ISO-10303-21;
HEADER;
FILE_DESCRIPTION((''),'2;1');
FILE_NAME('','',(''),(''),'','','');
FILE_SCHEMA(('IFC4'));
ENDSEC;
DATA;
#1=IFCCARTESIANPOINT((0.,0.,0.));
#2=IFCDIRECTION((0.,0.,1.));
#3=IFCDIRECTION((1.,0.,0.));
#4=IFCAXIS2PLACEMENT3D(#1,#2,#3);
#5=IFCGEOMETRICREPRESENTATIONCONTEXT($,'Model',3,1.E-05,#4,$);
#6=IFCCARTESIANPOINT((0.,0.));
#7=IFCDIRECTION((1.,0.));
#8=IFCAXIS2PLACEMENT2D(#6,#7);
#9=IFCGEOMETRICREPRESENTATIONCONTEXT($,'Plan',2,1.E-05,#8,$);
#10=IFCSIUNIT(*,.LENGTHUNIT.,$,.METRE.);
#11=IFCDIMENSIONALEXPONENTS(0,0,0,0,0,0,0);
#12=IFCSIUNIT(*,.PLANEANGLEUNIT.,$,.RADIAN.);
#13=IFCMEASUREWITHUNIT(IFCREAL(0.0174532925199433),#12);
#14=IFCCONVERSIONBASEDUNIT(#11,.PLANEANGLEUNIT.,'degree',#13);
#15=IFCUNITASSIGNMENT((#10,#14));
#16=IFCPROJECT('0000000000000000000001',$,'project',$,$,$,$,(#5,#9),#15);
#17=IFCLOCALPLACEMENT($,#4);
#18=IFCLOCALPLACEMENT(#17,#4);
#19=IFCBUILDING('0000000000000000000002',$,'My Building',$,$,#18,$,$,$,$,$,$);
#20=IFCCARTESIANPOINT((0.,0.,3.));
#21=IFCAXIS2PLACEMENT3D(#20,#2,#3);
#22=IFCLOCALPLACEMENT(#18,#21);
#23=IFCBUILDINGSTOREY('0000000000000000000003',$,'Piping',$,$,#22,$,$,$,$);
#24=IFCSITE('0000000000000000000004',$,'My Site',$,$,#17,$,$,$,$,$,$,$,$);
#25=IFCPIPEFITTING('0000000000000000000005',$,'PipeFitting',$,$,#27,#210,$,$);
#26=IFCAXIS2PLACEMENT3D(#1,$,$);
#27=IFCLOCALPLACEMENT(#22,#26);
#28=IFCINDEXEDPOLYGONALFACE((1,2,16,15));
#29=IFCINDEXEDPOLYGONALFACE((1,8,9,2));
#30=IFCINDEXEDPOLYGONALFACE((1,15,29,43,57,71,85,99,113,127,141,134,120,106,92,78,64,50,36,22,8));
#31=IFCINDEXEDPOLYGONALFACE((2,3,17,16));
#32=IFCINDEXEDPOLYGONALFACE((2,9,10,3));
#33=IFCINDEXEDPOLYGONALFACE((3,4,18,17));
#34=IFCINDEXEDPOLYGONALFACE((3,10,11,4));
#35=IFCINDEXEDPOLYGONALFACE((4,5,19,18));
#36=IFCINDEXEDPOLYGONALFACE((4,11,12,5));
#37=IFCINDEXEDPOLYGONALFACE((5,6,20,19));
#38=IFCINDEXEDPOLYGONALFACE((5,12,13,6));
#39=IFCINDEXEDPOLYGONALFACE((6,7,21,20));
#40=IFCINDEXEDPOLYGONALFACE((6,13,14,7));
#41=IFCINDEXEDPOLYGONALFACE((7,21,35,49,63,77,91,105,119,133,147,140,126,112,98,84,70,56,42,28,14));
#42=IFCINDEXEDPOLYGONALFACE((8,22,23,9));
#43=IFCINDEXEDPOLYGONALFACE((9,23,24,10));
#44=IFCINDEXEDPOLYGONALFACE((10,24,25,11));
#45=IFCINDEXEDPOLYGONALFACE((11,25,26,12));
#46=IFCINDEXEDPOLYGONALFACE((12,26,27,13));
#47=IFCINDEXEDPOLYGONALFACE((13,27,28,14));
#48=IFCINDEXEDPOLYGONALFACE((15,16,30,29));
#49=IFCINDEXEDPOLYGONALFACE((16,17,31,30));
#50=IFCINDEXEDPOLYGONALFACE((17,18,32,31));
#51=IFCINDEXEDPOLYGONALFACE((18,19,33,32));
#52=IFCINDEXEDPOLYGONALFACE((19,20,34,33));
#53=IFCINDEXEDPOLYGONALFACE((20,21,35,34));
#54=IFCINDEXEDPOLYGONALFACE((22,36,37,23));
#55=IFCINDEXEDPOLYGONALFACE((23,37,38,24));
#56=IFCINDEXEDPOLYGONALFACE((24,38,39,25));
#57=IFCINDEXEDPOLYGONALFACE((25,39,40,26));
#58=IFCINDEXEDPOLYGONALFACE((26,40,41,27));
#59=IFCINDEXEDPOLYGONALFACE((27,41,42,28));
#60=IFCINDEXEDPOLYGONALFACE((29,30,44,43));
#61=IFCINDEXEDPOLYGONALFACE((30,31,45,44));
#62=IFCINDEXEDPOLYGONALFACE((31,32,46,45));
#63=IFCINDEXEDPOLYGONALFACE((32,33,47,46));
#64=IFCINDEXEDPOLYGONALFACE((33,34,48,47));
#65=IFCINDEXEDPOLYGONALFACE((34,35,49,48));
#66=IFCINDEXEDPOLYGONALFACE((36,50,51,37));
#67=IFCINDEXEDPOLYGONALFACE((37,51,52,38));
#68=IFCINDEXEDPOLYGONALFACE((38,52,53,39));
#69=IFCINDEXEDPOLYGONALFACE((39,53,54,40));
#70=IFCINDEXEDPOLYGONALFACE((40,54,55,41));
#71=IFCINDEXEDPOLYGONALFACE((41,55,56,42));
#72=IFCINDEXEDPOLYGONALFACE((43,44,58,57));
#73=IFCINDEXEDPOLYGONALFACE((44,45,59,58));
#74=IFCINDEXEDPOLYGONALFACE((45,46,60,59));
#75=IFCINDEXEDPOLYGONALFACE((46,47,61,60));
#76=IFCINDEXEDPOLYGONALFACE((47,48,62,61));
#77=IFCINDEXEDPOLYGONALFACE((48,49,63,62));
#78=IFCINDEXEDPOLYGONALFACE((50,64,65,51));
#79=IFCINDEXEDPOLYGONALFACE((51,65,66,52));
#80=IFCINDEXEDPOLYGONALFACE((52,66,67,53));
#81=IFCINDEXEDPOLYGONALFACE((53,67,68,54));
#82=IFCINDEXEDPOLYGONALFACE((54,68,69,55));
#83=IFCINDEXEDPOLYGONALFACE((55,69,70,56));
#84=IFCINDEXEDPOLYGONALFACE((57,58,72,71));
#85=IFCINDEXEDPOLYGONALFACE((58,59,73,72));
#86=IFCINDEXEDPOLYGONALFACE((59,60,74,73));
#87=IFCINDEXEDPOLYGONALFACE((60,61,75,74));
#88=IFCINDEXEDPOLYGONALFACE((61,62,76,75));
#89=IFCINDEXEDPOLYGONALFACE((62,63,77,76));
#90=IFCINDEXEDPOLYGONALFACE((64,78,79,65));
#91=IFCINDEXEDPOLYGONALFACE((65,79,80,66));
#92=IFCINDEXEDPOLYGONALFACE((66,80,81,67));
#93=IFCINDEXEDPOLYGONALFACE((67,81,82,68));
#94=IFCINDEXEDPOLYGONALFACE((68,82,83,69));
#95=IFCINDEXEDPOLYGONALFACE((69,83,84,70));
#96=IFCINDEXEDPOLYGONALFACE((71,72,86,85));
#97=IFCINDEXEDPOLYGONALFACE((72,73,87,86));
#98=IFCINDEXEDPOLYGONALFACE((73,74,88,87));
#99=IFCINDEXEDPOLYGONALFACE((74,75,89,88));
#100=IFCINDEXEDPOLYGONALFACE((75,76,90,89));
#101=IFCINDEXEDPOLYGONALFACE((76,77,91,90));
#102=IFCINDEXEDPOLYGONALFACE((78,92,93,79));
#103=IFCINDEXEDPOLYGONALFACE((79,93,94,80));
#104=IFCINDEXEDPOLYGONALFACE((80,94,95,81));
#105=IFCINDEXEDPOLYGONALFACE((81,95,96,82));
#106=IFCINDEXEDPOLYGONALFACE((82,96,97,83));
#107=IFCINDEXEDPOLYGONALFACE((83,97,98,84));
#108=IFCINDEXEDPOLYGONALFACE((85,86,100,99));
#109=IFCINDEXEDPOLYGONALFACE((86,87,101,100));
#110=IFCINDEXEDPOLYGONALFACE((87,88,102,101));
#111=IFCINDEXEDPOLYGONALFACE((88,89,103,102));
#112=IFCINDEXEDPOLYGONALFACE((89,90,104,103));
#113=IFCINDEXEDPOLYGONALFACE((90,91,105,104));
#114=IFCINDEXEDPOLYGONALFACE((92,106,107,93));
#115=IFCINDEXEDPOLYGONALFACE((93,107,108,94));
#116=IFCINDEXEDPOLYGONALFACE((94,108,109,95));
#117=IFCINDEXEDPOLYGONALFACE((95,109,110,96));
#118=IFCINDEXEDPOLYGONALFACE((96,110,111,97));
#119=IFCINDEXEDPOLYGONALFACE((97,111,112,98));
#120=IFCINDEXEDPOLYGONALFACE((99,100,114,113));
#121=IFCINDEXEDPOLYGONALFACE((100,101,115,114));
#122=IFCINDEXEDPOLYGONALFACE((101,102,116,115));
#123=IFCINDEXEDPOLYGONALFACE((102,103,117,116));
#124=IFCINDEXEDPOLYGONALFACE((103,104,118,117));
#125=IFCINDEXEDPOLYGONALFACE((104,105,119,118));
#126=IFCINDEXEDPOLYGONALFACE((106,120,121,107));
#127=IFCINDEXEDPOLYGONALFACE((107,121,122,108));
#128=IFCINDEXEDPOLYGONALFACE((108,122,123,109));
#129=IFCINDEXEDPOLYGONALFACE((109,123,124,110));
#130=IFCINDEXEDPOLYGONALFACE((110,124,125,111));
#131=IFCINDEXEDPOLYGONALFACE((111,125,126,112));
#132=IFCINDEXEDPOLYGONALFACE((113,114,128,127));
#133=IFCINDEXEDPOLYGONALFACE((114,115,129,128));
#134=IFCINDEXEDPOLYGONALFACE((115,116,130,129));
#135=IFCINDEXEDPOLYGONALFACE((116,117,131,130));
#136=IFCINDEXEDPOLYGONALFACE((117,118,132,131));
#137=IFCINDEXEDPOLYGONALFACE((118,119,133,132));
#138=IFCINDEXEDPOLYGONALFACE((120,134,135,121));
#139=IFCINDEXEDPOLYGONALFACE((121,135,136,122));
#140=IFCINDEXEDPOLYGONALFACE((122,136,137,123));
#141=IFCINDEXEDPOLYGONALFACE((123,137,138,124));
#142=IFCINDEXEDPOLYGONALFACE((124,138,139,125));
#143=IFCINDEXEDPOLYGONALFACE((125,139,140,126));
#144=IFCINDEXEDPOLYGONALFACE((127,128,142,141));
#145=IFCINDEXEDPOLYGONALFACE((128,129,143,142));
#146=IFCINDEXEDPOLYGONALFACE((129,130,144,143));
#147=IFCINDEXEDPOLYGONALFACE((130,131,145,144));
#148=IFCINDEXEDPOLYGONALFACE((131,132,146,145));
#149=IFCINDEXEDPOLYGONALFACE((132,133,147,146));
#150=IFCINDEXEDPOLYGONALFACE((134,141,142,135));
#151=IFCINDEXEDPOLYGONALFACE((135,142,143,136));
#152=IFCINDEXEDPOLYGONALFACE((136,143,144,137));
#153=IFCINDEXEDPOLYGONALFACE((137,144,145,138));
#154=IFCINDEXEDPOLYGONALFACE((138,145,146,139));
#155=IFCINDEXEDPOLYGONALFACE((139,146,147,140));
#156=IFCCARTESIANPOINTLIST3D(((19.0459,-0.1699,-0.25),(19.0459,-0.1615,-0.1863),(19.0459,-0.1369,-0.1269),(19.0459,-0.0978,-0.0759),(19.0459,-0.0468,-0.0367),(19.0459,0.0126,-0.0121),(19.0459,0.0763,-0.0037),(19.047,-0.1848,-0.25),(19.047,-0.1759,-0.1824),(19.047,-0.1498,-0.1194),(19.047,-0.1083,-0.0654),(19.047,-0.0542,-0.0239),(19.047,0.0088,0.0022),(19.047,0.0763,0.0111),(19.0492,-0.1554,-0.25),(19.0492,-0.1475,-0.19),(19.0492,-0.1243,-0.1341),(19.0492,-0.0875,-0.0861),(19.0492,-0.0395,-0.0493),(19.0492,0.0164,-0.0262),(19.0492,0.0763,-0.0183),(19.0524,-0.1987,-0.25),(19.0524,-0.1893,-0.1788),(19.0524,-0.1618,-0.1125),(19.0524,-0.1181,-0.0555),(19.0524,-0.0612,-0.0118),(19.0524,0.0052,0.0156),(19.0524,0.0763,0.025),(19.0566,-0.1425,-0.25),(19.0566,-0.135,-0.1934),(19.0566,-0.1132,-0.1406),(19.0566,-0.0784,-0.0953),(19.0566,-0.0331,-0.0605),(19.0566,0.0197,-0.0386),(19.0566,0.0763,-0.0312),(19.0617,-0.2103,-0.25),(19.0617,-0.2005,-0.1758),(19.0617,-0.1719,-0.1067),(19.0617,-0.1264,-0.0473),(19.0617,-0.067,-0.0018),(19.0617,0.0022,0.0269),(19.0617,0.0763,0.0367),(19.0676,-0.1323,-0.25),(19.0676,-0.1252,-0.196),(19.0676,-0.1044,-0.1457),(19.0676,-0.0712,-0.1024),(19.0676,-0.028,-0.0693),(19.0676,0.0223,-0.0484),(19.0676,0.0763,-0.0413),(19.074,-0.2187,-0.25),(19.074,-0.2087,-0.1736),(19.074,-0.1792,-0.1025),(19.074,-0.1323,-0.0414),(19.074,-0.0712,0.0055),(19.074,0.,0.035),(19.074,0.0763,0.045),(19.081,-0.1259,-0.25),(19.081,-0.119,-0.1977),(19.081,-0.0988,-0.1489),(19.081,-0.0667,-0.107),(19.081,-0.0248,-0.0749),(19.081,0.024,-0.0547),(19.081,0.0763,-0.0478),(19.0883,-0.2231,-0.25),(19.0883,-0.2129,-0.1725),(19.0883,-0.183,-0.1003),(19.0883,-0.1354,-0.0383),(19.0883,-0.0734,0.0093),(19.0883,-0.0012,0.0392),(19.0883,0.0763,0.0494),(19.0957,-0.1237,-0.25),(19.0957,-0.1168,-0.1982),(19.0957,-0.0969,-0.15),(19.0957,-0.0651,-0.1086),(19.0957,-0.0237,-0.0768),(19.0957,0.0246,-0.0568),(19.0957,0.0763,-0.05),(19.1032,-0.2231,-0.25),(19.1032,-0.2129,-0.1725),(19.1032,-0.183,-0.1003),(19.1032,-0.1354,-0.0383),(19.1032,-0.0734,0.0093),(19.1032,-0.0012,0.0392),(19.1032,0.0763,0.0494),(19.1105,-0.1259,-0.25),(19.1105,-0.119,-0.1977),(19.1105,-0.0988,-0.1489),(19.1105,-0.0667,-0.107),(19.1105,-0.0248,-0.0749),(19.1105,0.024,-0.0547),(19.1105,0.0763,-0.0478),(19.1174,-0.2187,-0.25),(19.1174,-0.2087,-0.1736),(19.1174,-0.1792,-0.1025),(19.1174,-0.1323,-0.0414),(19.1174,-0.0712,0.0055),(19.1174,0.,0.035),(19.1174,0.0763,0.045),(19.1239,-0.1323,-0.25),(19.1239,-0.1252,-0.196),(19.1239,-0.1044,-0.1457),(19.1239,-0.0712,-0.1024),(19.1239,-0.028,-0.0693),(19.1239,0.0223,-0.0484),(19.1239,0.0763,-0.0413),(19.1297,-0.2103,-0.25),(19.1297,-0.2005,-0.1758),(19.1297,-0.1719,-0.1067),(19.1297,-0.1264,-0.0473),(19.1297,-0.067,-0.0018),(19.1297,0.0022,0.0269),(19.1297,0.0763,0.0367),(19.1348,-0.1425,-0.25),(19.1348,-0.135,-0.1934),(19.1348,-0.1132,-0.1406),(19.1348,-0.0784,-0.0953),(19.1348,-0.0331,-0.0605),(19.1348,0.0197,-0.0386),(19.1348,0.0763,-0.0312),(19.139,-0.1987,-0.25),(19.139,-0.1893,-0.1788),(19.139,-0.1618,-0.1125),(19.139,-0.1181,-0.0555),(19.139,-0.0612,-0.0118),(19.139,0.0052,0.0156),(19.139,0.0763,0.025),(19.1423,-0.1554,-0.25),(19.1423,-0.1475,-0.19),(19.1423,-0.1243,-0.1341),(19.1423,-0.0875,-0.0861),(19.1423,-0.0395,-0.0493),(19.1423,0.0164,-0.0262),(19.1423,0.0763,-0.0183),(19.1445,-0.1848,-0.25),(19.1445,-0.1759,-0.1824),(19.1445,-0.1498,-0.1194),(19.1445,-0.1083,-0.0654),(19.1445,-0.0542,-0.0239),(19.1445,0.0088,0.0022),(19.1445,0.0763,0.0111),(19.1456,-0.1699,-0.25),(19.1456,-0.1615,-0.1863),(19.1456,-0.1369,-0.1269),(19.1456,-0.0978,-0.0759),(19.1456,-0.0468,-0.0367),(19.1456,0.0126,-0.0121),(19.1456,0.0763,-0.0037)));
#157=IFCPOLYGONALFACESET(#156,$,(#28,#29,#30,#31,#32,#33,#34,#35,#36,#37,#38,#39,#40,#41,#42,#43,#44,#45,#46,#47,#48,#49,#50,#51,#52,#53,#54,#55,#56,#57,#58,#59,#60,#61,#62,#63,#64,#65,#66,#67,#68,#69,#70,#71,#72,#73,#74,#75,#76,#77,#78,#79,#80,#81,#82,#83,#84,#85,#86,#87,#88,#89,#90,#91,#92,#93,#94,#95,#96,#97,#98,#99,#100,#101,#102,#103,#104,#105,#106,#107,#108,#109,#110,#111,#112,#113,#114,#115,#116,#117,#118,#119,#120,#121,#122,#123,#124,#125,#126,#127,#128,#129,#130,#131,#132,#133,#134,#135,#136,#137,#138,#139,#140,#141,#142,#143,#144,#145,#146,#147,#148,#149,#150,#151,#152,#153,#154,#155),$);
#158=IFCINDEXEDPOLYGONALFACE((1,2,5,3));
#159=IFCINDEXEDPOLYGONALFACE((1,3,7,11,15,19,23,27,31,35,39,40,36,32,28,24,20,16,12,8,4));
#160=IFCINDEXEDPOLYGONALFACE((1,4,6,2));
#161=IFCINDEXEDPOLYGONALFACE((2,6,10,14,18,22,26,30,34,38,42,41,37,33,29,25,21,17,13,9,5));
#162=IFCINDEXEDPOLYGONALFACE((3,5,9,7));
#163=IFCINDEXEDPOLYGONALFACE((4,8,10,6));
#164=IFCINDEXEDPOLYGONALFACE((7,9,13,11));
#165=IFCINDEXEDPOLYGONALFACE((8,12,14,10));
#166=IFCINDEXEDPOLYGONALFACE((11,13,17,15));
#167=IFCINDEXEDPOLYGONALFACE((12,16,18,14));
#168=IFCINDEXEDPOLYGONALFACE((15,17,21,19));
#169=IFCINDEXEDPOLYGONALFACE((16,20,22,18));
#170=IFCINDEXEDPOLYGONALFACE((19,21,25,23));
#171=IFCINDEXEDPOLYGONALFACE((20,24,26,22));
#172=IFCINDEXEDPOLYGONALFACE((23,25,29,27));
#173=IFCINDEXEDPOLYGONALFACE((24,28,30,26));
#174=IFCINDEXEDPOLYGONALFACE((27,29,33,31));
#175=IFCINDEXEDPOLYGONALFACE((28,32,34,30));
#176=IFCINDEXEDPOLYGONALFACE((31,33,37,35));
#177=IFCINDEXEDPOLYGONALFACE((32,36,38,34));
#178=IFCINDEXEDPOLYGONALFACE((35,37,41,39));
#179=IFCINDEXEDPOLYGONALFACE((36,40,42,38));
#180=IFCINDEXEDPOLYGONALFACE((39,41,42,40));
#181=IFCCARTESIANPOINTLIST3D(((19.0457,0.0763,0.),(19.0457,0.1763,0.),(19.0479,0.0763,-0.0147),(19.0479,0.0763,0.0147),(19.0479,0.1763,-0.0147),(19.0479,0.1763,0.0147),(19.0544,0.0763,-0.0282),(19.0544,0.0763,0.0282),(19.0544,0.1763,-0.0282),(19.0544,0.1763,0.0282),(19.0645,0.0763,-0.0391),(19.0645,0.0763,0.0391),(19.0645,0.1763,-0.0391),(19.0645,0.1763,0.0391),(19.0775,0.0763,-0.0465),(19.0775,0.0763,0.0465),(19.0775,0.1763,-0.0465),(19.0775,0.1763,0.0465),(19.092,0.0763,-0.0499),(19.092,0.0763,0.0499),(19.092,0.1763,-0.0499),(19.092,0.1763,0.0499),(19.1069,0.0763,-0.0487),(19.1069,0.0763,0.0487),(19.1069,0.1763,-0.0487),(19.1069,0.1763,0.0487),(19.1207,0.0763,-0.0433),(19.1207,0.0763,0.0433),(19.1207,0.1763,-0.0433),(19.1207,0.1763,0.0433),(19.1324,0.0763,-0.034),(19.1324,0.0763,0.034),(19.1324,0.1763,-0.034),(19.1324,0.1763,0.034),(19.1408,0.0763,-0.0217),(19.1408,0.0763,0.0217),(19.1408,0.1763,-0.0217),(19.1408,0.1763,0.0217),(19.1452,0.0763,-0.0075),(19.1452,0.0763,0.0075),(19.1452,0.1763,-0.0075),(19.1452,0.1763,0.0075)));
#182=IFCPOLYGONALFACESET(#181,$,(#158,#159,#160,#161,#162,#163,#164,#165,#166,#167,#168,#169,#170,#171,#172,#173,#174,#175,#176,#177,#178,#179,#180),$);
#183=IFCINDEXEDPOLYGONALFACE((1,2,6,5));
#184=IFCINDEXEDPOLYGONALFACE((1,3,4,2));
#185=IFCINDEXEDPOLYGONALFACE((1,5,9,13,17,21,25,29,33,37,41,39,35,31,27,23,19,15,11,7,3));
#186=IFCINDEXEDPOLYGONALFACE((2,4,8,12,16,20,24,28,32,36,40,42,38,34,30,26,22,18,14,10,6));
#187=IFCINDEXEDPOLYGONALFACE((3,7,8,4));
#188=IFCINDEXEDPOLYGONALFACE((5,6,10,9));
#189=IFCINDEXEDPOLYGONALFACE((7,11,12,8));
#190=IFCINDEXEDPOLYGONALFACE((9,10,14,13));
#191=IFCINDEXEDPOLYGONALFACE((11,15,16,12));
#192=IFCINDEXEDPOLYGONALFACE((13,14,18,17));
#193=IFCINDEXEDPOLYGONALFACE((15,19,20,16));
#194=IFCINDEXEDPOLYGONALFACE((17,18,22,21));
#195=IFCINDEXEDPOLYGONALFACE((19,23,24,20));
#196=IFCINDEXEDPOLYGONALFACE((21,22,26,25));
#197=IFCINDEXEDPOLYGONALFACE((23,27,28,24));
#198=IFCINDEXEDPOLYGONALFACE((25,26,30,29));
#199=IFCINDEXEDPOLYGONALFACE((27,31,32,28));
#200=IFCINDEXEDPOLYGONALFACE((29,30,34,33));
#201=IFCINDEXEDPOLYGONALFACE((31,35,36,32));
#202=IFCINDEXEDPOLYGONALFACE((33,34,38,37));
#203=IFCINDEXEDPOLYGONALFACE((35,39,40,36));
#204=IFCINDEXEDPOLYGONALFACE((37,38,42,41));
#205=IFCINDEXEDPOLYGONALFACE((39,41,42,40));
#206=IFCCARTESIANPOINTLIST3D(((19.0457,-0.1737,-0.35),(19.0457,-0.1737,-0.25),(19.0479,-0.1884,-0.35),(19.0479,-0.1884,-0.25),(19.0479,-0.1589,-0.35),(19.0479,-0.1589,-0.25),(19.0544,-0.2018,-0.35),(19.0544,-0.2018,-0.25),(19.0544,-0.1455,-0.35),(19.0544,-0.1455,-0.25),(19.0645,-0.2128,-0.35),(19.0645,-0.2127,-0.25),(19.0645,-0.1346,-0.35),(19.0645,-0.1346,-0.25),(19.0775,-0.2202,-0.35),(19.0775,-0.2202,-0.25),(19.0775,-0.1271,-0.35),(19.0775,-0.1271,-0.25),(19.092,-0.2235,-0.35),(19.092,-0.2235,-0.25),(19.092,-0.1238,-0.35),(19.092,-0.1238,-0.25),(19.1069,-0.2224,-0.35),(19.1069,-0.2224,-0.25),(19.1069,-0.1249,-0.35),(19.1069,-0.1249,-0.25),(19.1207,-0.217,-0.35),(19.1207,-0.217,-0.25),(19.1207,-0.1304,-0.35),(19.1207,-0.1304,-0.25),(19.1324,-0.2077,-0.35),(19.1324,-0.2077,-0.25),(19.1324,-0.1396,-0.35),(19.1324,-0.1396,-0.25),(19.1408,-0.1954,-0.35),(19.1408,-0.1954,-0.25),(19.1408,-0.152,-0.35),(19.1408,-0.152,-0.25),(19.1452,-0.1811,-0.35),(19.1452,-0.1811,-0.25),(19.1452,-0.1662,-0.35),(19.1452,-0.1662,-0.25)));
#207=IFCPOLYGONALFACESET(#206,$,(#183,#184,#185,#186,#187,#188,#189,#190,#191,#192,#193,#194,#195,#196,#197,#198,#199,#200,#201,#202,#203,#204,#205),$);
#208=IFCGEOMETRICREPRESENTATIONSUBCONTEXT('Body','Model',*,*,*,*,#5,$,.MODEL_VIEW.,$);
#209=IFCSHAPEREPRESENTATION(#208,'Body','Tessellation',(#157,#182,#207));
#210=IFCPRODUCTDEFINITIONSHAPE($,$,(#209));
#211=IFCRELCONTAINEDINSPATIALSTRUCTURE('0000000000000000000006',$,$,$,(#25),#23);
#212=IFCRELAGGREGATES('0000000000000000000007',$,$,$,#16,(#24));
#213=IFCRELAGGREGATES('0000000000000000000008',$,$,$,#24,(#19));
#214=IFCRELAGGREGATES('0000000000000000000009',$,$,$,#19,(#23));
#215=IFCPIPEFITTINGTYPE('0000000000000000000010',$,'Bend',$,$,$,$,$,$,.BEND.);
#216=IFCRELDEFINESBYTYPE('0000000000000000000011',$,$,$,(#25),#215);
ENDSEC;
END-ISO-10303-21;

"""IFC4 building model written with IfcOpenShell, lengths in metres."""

from ifc_helpers import new_model, entity, si_unit, converted_unit, frame, origin_with_axes, origin_2d_with_axis, place, context, subcontext, project, spatial, circle, extrude, source, transform, mapped, type_object, type_shapes, element, save


model = new_model("IFC4")

# Units and contexts
model_context = context("Model", 3, precision=1e-05, world=origin_with_axes())
plan_context = context("Plan", 2, precision=1e-05, world=origin_2d_with_axis())
body_context = subcontext(model_context, "Body", "Model", "MODEL_VIEW")
ifc_project = project(units=[si_unit("LENGTHUNIT", "METRE"), converted_unit("PLANEANGLEUNIT", "degree", entity("IfcReal", 0.0174532925199433), si_unit("PLANEANGLEUNIT", "RADIAN"), dimensions=[0, 0, 0, 0, 0, 0, 0])], contexts=[model_context, plan_context])

# Site, building, storey
site_placement = place(None, origin_with_axes())
site = spatial("IfcSite", under=ifc_project, at=site_placement, Name="My Site")
building_placement = place(site_placement, origin_with_axes())
building = spatial("IfcBuilding", under=site, at=building_placement, Name="My Building")
storey_placement = place(building_placement, frame((0.0, 0.0, 3.0), z_axis=(0.0, 0.0, 1.0), x_axis=(1.0, 0.0, 0.0)))
storey = spatial("IfcBuildingStorey", under=building, at=storey_placement, Name="Piping")

# Pipe fitting
pipe_fitting_type = type_object("IfcPipeFittingType", Name="Bend", PredefinedType="BEND")
shared_shape = source(origin_with_axes(), body_context, "Body", "SolidModel", [
    entity("IfcSweptDiskSolid", entity("IfcIndexedPolyCurve", entity("IfcCartesianPointList3D", [[0.0, 0.0, -0.1], [0.0, -0.0732, -0.2768], [0.0, -0.25, -0.35]]), [entity("IfcArcIndex", [1, 2, 3])]), 0.05),
    extrude(circle(Radius=0.05), origin_with_axes(), (0.0, 0.0, -1.0), 0.1),
    extrude(circle(Radius=0.05), frame((0.0, -0.25, -0.35), z_axis=(0.0, -1.0, 0.0), x_axis=(1.0, 0.0, 0.0)), (0.0, 0.0, 1.0), 0.1),
])
type_shapes(pipe_fitting_type, [shared_shape])
for number, where, z_axis, x_axis, name in (
    (1, (19.0957, 0.1763, 0.0), (0.0, 1.0, 0.0), (-1.0, 0.0, 0.0), "PipeFitting"),
):
    element("IfcPipeFitting", number, at=place(storey_placement, frame(where, z_axis=z_axis, x_axis=x_axis)), inside=storey, type_object=pipe_fitting_type, Name=name, context=body_context, shape_type="MappedRepresentation", body=[
        mapped(shared_shape, transform((0.0, 0.0, 0.0), x_axis=(1.0, 0.0, 0.0), y_axis=(0.0, 1.0, 0.0), z_axis=(0.0, 0.0, 1.0), scale=1.0)),
    ])

save(model, "model.ifc")
